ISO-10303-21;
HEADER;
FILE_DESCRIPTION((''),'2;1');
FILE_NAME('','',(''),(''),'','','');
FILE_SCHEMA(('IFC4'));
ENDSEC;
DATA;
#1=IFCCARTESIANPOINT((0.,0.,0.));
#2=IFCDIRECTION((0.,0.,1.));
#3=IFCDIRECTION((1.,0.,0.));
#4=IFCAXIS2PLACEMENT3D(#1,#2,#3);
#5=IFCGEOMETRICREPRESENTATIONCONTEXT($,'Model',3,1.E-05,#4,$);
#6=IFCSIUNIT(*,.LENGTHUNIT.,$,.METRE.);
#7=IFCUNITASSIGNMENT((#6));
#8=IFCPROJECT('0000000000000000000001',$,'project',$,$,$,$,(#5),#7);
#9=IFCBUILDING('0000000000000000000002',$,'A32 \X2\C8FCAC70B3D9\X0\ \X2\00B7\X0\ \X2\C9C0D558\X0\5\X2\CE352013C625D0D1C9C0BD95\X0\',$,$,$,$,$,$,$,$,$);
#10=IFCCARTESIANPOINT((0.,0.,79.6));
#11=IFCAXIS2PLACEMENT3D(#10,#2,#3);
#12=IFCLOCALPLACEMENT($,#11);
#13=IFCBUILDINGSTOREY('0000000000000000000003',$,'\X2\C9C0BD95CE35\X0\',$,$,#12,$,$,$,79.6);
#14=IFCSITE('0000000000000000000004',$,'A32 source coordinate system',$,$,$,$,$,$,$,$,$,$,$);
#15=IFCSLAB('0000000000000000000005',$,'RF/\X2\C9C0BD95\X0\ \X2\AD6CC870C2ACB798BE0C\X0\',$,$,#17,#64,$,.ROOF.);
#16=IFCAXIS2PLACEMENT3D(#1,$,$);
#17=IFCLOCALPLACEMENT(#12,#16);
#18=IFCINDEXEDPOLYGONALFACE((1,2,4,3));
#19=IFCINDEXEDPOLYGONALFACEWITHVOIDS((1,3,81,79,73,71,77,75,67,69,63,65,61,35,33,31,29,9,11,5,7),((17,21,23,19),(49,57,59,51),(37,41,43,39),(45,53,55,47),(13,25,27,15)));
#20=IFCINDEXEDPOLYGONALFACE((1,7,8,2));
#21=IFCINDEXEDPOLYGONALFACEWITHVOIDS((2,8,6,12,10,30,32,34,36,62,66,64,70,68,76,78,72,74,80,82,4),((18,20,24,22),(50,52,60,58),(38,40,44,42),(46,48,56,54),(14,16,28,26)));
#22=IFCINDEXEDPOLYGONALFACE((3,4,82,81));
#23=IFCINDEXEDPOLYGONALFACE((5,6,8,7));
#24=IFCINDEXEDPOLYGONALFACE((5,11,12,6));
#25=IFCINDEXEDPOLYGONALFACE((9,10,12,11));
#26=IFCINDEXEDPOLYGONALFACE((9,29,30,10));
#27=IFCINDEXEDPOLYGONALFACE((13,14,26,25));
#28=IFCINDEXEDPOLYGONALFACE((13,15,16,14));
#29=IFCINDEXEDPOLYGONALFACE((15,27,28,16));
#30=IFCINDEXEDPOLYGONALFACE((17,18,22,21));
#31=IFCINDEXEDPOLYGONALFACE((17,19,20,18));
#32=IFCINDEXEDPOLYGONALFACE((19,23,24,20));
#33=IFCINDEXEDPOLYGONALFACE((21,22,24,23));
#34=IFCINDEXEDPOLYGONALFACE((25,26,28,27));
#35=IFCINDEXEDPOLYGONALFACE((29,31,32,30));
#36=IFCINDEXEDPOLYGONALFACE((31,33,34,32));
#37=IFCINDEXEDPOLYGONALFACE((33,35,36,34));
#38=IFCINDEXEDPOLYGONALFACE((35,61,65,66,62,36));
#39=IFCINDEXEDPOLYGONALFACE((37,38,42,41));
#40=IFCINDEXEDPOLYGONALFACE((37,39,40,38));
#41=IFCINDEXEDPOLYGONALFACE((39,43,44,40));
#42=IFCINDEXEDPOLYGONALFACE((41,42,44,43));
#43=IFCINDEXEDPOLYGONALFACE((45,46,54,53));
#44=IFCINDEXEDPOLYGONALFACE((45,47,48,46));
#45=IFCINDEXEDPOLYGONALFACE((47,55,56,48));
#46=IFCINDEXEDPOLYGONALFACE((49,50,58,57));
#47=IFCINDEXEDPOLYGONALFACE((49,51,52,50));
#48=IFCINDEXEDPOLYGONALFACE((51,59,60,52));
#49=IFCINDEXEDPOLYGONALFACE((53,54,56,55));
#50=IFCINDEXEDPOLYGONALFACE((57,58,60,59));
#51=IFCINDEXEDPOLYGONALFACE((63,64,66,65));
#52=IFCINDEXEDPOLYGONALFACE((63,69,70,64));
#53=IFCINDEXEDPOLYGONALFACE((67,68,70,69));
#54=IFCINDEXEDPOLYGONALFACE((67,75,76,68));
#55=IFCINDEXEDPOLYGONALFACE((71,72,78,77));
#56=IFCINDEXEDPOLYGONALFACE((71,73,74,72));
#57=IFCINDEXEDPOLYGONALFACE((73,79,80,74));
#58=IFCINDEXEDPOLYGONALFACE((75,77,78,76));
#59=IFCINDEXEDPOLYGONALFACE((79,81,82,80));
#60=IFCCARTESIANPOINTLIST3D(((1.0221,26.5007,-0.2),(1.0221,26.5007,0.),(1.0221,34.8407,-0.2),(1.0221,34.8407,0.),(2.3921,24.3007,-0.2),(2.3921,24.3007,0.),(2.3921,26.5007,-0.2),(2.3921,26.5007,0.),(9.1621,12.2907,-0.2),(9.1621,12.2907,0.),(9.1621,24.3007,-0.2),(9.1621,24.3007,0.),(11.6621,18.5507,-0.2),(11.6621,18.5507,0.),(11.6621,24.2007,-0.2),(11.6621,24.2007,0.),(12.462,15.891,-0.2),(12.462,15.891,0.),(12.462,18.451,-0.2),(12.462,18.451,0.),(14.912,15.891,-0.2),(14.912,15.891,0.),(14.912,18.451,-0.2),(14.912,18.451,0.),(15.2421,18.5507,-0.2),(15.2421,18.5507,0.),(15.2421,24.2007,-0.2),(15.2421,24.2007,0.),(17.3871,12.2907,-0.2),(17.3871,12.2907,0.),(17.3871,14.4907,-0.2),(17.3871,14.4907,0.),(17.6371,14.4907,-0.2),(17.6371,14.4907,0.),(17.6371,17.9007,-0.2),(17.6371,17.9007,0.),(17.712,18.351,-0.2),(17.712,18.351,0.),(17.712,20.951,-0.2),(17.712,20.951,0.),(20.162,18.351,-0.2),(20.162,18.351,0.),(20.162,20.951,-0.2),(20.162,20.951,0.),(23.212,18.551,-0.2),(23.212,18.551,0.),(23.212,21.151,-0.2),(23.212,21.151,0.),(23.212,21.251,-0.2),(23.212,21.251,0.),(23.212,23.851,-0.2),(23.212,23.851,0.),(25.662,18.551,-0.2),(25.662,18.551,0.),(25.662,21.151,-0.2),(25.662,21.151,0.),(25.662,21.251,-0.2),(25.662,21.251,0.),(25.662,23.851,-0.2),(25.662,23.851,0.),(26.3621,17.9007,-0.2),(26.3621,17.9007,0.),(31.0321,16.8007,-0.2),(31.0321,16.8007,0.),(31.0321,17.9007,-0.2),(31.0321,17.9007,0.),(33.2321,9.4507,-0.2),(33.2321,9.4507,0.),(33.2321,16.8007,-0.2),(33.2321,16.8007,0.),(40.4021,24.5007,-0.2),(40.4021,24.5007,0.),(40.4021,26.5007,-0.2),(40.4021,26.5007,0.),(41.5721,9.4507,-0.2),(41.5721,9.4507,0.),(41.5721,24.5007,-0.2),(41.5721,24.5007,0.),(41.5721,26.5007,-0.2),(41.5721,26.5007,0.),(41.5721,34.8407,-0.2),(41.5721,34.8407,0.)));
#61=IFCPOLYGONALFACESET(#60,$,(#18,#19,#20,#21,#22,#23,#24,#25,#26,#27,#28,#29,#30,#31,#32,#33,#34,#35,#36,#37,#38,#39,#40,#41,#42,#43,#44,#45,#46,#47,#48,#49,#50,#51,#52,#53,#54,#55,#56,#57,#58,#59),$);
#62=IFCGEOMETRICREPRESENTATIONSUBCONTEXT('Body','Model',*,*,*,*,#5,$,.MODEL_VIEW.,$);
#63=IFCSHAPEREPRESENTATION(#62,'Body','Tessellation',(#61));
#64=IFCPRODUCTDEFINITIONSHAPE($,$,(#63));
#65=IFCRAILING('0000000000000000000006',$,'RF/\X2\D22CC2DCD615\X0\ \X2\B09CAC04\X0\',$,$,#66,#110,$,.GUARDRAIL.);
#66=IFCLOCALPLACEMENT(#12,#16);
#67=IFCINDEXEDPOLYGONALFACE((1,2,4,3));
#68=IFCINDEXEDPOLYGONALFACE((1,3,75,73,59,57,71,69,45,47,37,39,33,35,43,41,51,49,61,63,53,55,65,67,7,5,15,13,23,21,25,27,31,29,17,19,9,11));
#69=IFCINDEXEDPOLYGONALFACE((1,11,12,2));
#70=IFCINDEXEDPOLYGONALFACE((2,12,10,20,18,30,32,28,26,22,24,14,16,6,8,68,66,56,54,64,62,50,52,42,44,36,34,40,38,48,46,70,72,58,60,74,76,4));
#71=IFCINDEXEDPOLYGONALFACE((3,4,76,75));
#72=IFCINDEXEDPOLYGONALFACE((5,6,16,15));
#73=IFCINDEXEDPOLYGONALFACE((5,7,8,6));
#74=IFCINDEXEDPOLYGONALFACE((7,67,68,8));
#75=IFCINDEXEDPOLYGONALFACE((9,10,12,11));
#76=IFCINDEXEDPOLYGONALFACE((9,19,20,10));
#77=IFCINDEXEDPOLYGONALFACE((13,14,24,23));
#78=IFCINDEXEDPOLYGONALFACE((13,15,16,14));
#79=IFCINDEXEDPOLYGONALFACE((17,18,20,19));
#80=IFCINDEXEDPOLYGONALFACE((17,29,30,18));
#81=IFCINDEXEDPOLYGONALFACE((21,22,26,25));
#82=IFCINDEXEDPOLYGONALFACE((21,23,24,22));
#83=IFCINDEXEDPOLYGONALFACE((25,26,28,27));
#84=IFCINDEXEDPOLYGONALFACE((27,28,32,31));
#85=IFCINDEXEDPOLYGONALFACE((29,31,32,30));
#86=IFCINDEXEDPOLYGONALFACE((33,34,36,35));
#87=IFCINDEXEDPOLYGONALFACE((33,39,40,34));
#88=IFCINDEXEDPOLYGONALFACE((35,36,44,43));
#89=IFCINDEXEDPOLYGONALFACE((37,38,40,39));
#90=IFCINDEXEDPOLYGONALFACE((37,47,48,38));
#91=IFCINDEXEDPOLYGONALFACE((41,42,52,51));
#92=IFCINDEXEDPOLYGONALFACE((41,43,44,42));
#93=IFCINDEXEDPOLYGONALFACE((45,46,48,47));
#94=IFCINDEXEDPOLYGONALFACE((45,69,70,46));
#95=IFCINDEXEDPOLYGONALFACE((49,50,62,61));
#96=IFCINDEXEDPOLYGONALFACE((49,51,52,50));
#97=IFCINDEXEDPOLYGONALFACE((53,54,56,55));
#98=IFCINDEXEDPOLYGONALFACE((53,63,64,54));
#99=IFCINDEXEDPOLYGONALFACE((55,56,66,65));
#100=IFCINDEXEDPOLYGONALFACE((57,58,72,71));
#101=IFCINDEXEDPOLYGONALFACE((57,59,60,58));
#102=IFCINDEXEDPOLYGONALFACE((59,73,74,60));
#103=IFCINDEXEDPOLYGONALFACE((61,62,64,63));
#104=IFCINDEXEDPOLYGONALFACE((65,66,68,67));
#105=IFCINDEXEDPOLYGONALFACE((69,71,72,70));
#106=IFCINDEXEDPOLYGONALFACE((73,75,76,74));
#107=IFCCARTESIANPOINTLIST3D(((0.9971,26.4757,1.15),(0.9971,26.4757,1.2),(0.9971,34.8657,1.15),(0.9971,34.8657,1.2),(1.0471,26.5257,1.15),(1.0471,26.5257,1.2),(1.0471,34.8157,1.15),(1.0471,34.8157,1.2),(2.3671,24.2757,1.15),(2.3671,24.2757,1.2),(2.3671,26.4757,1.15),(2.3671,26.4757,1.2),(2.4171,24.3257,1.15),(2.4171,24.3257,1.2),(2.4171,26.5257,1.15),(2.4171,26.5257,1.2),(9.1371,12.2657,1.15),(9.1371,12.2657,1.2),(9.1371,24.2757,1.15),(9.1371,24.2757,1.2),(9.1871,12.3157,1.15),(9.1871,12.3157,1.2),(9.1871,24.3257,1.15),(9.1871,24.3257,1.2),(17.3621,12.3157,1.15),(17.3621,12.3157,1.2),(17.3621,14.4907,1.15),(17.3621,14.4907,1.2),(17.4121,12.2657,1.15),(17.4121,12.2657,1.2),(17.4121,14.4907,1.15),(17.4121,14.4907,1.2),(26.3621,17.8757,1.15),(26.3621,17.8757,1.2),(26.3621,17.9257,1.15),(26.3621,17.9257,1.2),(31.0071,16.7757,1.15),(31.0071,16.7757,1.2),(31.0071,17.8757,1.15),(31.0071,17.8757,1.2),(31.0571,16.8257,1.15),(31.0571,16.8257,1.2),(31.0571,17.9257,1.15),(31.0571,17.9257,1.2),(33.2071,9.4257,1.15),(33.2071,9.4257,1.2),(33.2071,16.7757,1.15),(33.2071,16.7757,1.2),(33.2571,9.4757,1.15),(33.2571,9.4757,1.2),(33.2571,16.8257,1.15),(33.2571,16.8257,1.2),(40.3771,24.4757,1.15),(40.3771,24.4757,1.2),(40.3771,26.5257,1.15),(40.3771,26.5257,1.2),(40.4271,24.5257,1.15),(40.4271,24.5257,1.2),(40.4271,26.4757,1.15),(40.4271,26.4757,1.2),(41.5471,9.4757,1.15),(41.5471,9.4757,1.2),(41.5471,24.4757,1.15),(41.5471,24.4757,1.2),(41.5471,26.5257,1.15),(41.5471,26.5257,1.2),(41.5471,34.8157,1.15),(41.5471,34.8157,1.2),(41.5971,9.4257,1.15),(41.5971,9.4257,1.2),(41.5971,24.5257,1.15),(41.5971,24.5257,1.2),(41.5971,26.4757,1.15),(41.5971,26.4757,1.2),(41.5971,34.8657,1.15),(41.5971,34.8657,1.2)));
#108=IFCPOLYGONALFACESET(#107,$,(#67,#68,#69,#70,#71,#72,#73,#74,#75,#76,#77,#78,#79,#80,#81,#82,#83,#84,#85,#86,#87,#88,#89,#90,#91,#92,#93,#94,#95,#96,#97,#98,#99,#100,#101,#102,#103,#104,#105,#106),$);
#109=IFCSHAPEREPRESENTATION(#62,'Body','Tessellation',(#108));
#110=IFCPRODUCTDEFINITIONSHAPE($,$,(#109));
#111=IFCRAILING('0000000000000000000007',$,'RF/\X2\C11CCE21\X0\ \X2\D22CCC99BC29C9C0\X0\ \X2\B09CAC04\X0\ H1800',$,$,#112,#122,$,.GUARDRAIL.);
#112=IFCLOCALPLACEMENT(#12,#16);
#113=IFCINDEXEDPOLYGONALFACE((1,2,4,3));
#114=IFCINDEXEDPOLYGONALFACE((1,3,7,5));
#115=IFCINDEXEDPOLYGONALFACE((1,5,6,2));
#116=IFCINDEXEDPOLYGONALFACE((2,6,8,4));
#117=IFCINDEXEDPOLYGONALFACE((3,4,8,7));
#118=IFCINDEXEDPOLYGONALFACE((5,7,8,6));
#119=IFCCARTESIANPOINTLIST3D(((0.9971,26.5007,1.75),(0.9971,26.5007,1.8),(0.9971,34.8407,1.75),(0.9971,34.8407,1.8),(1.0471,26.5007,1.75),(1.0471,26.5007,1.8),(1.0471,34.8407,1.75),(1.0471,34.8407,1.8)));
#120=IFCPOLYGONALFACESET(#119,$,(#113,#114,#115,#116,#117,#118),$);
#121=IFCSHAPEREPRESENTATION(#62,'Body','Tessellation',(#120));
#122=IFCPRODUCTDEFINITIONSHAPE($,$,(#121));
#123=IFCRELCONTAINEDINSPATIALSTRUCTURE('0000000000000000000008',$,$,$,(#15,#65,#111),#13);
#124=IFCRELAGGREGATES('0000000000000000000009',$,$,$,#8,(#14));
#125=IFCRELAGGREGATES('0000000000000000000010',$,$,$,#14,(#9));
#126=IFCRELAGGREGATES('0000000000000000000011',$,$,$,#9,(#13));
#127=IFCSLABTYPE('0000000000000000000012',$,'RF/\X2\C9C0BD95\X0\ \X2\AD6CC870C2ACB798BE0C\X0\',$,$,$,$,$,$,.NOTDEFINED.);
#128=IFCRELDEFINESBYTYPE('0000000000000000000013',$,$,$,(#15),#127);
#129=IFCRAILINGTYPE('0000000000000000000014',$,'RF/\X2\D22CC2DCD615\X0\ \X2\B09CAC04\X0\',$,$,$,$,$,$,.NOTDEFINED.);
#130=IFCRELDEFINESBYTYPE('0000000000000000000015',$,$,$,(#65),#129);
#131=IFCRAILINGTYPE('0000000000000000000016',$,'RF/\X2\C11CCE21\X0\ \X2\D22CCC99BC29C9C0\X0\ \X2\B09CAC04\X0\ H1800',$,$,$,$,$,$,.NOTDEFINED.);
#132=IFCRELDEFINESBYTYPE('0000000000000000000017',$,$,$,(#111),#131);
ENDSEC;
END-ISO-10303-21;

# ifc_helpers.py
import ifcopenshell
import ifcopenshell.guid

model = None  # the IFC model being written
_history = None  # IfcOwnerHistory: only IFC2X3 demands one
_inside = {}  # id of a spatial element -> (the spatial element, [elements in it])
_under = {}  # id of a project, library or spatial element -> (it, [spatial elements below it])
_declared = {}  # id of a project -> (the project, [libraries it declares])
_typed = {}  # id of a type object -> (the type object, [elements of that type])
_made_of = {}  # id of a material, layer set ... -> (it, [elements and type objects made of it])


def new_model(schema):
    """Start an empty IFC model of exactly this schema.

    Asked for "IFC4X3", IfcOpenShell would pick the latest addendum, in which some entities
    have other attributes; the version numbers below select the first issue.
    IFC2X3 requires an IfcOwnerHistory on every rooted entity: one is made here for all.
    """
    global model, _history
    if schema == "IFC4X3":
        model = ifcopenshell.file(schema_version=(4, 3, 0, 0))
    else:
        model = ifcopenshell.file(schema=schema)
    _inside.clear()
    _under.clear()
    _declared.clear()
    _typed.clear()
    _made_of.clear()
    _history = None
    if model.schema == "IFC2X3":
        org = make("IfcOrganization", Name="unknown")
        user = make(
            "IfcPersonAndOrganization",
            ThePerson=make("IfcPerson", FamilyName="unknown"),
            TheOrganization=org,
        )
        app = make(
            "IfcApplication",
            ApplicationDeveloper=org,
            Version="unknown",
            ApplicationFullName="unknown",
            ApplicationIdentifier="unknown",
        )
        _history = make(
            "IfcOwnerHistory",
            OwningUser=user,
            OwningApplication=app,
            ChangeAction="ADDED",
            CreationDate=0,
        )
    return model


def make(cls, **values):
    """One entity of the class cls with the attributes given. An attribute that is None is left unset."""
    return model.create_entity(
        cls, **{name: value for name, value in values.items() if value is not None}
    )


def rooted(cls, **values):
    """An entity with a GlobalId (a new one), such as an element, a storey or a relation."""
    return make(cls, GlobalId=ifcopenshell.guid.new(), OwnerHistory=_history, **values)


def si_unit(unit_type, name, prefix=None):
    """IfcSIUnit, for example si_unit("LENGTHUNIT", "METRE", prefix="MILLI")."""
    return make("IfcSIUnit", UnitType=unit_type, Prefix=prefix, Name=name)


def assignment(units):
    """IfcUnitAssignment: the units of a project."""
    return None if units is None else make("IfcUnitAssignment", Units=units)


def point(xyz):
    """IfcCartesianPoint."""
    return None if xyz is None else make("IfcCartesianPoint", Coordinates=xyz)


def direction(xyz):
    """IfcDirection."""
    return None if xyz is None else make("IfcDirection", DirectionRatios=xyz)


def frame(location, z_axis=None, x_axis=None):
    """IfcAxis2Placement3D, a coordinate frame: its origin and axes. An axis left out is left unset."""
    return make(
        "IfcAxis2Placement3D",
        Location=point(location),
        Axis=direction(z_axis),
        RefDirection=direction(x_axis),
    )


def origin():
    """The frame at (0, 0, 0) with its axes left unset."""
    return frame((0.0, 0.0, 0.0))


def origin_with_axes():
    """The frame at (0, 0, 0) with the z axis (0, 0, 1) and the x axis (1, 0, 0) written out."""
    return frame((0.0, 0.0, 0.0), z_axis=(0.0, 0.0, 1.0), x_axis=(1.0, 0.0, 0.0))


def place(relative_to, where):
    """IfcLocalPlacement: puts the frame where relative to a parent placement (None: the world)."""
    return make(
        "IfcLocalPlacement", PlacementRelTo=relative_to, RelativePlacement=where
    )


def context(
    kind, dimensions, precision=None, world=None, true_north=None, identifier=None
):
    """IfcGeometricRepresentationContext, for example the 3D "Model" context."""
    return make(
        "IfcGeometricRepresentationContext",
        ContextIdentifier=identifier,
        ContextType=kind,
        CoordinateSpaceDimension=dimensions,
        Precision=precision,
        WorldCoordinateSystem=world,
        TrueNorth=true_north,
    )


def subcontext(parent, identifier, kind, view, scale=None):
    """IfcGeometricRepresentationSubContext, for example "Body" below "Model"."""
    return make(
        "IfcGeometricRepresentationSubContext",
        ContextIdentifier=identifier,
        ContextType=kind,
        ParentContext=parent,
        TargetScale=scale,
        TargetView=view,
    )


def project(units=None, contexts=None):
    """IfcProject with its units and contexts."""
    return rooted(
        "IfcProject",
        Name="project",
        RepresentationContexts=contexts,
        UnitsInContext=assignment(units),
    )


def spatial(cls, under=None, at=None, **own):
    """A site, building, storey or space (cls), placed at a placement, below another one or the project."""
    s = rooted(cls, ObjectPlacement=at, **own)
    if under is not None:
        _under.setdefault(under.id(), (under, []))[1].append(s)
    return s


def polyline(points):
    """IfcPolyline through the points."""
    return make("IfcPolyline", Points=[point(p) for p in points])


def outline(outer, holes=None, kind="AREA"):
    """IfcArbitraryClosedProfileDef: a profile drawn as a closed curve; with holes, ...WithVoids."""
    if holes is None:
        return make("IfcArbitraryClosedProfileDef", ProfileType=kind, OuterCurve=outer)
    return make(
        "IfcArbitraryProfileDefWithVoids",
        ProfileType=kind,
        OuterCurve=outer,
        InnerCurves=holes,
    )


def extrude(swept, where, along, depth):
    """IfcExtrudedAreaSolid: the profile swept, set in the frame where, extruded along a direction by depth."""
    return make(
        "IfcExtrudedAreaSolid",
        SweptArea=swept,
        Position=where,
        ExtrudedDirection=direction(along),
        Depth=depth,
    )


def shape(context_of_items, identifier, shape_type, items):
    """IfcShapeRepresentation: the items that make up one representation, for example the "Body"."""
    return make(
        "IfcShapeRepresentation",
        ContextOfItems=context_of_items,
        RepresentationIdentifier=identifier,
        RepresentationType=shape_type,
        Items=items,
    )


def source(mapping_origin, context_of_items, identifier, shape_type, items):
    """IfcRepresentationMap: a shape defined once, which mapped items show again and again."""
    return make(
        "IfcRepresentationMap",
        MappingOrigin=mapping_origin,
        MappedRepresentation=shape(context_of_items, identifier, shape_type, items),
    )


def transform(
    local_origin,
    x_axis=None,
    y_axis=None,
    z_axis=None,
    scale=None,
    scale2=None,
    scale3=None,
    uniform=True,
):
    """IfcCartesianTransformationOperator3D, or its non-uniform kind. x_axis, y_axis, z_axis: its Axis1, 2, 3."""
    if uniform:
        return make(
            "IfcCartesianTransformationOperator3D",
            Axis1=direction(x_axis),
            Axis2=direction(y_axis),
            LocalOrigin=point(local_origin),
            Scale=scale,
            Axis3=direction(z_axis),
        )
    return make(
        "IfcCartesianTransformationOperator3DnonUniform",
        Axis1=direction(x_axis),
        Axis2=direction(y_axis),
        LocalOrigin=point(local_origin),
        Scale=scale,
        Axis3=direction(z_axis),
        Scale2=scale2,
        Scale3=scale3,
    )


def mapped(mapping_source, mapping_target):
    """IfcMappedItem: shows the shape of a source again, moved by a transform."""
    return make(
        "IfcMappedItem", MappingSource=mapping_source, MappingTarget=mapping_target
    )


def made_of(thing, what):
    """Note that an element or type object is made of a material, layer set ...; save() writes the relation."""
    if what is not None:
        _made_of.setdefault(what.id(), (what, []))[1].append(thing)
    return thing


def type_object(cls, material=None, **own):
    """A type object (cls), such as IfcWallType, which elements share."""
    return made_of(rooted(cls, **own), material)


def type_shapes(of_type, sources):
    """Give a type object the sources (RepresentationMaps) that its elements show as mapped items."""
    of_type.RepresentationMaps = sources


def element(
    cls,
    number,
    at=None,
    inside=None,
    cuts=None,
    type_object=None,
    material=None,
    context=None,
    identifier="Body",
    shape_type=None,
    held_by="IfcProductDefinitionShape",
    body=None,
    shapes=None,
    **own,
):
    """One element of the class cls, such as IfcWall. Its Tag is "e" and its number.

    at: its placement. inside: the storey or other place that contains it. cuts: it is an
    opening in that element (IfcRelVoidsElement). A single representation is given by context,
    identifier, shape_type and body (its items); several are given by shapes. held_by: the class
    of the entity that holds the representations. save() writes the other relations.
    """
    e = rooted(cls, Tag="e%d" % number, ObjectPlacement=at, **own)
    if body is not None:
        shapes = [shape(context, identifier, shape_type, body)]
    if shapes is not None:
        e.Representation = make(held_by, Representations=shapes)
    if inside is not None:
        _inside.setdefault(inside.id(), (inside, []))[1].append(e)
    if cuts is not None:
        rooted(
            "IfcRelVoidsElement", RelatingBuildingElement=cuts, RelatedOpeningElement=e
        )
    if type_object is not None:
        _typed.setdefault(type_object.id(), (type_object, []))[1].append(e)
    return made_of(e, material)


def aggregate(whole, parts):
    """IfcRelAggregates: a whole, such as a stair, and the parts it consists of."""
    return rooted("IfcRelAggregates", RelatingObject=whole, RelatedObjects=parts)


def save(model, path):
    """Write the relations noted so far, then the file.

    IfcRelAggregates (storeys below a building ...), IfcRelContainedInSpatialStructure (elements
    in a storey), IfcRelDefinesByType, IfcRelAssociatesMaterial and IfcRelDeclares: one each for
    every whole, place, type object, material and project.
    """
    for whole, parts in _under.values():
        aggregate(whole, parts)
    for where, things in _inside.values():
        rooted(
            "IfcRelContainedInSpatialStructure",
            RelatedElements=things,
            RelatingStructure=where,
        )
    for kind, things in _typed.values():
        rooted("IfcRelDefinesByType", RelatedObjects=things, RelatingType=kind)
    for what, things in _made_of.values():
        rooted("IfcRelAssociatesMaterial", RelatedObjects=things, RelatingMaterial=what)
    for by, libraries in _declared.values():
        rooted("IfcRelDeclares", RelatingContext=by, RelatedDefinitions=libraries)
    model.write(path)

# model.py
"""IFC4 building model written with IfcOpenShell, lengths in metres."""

from ifc_helpers import new_model, si_unit, frame, origin, origin_with_axes, place, context, subcontext, project, spatial, polyline, outline, extrude, source, transform, mapped, type_object, type_shapes, element, save


model = new_model("IFC4")

# Units and contexts
model_context = context("Model", 3, precision=1e-05, world=origin_with_axes())
body_context = subcontext(model_context, "Body", "Model", "MODEL_VIEW")
ifc_project = project(units=[si_unit("LENGTHUNIT", "METRE")], contexts=[model_context])

# Site, building, storey
site = spatial("IfcSite", under=ifc_project, Name="A32 source coordinate system")
building = spatial("IfcBuilding", under=site, Name="A32 주거동 · 지하5층–옥탑지붕")
storey_placement = place(None, frame((0.0, 0.0, 79.6), z_axis=(0.0, 0.0, 1.0), x_axis=(1.0, 0.0, 0.0)))
storey = spatial("IfcBuildingStorey", under=building, at=storey_placement, Name="지붕층", Elevation=79.6)

# Slab
slab_type = type_object("IfcSlabType", Name="RF/지붕 구조슬래브", PredefinedType="NOTDEFINED")
shared_shape_1 = source(origin(), body_context, "Body", "SweptSolid", [
    extrude(outline(polyline([(9.1621, 12.2907), (9.1621, 24.3007), (2.3921, 24.3007), (2.3921, 26.5007), (1.0221, 26.5007), (1.0221, 34.8407), (41.5721, 34.8407), (41.5721, 26.5007), (40.4021, 26.5007), (40.4021, 24.5007), (41.5721, 24.5007), (41.5721, 9.4507), (33.2321, 9.4507), (33.2321, 16.8007), (31.0321, 16.8007), (31.0321, 17.9007), (26.3621, 17.9007), (17.6371, 17.9007), (17.6371, 14.4907), (17.3871, 14.4907), (17.3871, 12.2907), (9.1621, 12.2907)]), holes=[polyline([(25.662, 18.551), (25.662, 21.151), (23.212, 21.151), (23.212, 18.551), (25.662, 18.551)]), polyline([(25.662, 21.251), (25.662, 23.851), (23.212, 23.851), (23.212, 21.251), (25.662, 21.251)]), polyline([(20.162, 18.351), (20.162, 20.951), (17.712, 20.951), (17.712, 18.351), (20.162, 18.351)]), polyline([(15.2421, 24.2007), (11.6621, 24.2007), (11.6621, 18.5507), (15.2421, 18.5507), (15.2421, 24.2007)]), polyline([(14.912, 15.891), (14.912, 18.451), (12.462, 18.451), (12.462, 15.891), (14.912, 15.891)])]), frame((0.0, 0.0, -0.2)), (0.0, 0.0, 1.0), 0.2),
])
type_shapes(slab_type, [shared_shape_1])
slab_placement = place(storey_placement, origin_with_axes())
element("IfcSlab", 1, at=slab_placement, inside=storey, type_object=slab_type, Name="RF/지붕 구조슬래브", PredefinedType="ROOF", context=body_context, shape_type="MappedRepresentation", body=[
    mapped(shared_shape_1, transform((0.0, 0.0, 0.0), scale=1.0)),
])

# Railings
railing_type_1 = type_object("IfcRailingType", Name="RF/투시형 난간", PredefinedType="NOTDEFINED")
shared_shape_2 = source(origin(), body_context, "Body", "SweptSolid", [
    extrude(outline(polyline([(17.4121, 12.2657), (9.1371, 12.2657), (9.1371, 24.2757), (2.3671, 24.2757), (2.3671, 26.4757), (0.9971, 26.4757), (0.9971, 34.8657), (41.5971, 34.8657), (41.5971, 26.4757), (40.4271, 26.4757), (40.4271, 24.5257), (41.5971, 24.5257), (41.5971, 9.4257), (33.2071, 9.4257), (33.2071, 16.7757), (31.0071, 16.7757), (31.0071, 17.8757), (26.3621, 17.8757), (26.3621, 17.9257), (31.0571, 17.9257), (31.0571, 16.8257), (33.2571, 16.8257), (33.2571, 9.4757), (41.5471, 9.4757), (41.5471, 24.4757), (40.3771, 24.4757), (40.3771, 26.5257), (41.5471, 26.5257), (41.5471, 34.8157), (1.0471, 34.8157), (1.0471, 26.5257), (2.4171, 26.5257), (2.4171, 24.3257), (9.1871, 24.3257), (9.1871, 12.3157), (17.3621, 12.3157), (17.3621, 14.4907), (17.4121, 14.4907), (17.4121, 12.2657)])), frame((0.0, 0.0, 1.15)), (0.0, 0.0, 1.0), 0.05),
])
type_shapes(railing_type_1, [shared_shape_2])
railing_1_placement = place(storey_placement, origin_with_axes())
element("IfcRailing", 2, at=railing_1_placement, inside=storey, type_object=railing_type_1, Name="RF/투시형 난간", PredefinedType="GUARDRAIL", context=body_context, shape_type="MappedRepresentation", body=[
    mapped(shared_shape_2, transform((0.0, 0.0, 0.0), scale=1.0)),
])
railing_type_2 = type_object("IfcRailingType", Name="RF/서측 투척방지 난간 H1800", PredefinedType="NOTDEFINED")
shared_shape_3 = source(origin(), body_context, "Body", "SweptSolid", [
    extrude(outline(polyline([(0.9971, 34.8407), (1.0471, 34.8407), (1.0471, 26.5007), (0.9971, 26.5007), (0.9971, 34.8407)])), frame((0.0, 0.0, 1.75)), (0.0, 0.0, 1.0), 0.05),
])
type_shapes(railing_type_2, [shared_shape_3])
railing_2_placement = place(storey_placement, origin_with_axes())
element("IfcRailing", 3, at=railing_2_placement, inside=storey, type_object=railing_type_2, Name="RF/서측 투척방지 난간 H1800", PredefinedType="GUARDRAIL", context=body_context, shape_type="MappedRepresentation", body=[
    mapped(shared_shape_3, transform((0.0, 0.0, 0.0), scale=1.0)),
])

save(model, "model.ifc")
